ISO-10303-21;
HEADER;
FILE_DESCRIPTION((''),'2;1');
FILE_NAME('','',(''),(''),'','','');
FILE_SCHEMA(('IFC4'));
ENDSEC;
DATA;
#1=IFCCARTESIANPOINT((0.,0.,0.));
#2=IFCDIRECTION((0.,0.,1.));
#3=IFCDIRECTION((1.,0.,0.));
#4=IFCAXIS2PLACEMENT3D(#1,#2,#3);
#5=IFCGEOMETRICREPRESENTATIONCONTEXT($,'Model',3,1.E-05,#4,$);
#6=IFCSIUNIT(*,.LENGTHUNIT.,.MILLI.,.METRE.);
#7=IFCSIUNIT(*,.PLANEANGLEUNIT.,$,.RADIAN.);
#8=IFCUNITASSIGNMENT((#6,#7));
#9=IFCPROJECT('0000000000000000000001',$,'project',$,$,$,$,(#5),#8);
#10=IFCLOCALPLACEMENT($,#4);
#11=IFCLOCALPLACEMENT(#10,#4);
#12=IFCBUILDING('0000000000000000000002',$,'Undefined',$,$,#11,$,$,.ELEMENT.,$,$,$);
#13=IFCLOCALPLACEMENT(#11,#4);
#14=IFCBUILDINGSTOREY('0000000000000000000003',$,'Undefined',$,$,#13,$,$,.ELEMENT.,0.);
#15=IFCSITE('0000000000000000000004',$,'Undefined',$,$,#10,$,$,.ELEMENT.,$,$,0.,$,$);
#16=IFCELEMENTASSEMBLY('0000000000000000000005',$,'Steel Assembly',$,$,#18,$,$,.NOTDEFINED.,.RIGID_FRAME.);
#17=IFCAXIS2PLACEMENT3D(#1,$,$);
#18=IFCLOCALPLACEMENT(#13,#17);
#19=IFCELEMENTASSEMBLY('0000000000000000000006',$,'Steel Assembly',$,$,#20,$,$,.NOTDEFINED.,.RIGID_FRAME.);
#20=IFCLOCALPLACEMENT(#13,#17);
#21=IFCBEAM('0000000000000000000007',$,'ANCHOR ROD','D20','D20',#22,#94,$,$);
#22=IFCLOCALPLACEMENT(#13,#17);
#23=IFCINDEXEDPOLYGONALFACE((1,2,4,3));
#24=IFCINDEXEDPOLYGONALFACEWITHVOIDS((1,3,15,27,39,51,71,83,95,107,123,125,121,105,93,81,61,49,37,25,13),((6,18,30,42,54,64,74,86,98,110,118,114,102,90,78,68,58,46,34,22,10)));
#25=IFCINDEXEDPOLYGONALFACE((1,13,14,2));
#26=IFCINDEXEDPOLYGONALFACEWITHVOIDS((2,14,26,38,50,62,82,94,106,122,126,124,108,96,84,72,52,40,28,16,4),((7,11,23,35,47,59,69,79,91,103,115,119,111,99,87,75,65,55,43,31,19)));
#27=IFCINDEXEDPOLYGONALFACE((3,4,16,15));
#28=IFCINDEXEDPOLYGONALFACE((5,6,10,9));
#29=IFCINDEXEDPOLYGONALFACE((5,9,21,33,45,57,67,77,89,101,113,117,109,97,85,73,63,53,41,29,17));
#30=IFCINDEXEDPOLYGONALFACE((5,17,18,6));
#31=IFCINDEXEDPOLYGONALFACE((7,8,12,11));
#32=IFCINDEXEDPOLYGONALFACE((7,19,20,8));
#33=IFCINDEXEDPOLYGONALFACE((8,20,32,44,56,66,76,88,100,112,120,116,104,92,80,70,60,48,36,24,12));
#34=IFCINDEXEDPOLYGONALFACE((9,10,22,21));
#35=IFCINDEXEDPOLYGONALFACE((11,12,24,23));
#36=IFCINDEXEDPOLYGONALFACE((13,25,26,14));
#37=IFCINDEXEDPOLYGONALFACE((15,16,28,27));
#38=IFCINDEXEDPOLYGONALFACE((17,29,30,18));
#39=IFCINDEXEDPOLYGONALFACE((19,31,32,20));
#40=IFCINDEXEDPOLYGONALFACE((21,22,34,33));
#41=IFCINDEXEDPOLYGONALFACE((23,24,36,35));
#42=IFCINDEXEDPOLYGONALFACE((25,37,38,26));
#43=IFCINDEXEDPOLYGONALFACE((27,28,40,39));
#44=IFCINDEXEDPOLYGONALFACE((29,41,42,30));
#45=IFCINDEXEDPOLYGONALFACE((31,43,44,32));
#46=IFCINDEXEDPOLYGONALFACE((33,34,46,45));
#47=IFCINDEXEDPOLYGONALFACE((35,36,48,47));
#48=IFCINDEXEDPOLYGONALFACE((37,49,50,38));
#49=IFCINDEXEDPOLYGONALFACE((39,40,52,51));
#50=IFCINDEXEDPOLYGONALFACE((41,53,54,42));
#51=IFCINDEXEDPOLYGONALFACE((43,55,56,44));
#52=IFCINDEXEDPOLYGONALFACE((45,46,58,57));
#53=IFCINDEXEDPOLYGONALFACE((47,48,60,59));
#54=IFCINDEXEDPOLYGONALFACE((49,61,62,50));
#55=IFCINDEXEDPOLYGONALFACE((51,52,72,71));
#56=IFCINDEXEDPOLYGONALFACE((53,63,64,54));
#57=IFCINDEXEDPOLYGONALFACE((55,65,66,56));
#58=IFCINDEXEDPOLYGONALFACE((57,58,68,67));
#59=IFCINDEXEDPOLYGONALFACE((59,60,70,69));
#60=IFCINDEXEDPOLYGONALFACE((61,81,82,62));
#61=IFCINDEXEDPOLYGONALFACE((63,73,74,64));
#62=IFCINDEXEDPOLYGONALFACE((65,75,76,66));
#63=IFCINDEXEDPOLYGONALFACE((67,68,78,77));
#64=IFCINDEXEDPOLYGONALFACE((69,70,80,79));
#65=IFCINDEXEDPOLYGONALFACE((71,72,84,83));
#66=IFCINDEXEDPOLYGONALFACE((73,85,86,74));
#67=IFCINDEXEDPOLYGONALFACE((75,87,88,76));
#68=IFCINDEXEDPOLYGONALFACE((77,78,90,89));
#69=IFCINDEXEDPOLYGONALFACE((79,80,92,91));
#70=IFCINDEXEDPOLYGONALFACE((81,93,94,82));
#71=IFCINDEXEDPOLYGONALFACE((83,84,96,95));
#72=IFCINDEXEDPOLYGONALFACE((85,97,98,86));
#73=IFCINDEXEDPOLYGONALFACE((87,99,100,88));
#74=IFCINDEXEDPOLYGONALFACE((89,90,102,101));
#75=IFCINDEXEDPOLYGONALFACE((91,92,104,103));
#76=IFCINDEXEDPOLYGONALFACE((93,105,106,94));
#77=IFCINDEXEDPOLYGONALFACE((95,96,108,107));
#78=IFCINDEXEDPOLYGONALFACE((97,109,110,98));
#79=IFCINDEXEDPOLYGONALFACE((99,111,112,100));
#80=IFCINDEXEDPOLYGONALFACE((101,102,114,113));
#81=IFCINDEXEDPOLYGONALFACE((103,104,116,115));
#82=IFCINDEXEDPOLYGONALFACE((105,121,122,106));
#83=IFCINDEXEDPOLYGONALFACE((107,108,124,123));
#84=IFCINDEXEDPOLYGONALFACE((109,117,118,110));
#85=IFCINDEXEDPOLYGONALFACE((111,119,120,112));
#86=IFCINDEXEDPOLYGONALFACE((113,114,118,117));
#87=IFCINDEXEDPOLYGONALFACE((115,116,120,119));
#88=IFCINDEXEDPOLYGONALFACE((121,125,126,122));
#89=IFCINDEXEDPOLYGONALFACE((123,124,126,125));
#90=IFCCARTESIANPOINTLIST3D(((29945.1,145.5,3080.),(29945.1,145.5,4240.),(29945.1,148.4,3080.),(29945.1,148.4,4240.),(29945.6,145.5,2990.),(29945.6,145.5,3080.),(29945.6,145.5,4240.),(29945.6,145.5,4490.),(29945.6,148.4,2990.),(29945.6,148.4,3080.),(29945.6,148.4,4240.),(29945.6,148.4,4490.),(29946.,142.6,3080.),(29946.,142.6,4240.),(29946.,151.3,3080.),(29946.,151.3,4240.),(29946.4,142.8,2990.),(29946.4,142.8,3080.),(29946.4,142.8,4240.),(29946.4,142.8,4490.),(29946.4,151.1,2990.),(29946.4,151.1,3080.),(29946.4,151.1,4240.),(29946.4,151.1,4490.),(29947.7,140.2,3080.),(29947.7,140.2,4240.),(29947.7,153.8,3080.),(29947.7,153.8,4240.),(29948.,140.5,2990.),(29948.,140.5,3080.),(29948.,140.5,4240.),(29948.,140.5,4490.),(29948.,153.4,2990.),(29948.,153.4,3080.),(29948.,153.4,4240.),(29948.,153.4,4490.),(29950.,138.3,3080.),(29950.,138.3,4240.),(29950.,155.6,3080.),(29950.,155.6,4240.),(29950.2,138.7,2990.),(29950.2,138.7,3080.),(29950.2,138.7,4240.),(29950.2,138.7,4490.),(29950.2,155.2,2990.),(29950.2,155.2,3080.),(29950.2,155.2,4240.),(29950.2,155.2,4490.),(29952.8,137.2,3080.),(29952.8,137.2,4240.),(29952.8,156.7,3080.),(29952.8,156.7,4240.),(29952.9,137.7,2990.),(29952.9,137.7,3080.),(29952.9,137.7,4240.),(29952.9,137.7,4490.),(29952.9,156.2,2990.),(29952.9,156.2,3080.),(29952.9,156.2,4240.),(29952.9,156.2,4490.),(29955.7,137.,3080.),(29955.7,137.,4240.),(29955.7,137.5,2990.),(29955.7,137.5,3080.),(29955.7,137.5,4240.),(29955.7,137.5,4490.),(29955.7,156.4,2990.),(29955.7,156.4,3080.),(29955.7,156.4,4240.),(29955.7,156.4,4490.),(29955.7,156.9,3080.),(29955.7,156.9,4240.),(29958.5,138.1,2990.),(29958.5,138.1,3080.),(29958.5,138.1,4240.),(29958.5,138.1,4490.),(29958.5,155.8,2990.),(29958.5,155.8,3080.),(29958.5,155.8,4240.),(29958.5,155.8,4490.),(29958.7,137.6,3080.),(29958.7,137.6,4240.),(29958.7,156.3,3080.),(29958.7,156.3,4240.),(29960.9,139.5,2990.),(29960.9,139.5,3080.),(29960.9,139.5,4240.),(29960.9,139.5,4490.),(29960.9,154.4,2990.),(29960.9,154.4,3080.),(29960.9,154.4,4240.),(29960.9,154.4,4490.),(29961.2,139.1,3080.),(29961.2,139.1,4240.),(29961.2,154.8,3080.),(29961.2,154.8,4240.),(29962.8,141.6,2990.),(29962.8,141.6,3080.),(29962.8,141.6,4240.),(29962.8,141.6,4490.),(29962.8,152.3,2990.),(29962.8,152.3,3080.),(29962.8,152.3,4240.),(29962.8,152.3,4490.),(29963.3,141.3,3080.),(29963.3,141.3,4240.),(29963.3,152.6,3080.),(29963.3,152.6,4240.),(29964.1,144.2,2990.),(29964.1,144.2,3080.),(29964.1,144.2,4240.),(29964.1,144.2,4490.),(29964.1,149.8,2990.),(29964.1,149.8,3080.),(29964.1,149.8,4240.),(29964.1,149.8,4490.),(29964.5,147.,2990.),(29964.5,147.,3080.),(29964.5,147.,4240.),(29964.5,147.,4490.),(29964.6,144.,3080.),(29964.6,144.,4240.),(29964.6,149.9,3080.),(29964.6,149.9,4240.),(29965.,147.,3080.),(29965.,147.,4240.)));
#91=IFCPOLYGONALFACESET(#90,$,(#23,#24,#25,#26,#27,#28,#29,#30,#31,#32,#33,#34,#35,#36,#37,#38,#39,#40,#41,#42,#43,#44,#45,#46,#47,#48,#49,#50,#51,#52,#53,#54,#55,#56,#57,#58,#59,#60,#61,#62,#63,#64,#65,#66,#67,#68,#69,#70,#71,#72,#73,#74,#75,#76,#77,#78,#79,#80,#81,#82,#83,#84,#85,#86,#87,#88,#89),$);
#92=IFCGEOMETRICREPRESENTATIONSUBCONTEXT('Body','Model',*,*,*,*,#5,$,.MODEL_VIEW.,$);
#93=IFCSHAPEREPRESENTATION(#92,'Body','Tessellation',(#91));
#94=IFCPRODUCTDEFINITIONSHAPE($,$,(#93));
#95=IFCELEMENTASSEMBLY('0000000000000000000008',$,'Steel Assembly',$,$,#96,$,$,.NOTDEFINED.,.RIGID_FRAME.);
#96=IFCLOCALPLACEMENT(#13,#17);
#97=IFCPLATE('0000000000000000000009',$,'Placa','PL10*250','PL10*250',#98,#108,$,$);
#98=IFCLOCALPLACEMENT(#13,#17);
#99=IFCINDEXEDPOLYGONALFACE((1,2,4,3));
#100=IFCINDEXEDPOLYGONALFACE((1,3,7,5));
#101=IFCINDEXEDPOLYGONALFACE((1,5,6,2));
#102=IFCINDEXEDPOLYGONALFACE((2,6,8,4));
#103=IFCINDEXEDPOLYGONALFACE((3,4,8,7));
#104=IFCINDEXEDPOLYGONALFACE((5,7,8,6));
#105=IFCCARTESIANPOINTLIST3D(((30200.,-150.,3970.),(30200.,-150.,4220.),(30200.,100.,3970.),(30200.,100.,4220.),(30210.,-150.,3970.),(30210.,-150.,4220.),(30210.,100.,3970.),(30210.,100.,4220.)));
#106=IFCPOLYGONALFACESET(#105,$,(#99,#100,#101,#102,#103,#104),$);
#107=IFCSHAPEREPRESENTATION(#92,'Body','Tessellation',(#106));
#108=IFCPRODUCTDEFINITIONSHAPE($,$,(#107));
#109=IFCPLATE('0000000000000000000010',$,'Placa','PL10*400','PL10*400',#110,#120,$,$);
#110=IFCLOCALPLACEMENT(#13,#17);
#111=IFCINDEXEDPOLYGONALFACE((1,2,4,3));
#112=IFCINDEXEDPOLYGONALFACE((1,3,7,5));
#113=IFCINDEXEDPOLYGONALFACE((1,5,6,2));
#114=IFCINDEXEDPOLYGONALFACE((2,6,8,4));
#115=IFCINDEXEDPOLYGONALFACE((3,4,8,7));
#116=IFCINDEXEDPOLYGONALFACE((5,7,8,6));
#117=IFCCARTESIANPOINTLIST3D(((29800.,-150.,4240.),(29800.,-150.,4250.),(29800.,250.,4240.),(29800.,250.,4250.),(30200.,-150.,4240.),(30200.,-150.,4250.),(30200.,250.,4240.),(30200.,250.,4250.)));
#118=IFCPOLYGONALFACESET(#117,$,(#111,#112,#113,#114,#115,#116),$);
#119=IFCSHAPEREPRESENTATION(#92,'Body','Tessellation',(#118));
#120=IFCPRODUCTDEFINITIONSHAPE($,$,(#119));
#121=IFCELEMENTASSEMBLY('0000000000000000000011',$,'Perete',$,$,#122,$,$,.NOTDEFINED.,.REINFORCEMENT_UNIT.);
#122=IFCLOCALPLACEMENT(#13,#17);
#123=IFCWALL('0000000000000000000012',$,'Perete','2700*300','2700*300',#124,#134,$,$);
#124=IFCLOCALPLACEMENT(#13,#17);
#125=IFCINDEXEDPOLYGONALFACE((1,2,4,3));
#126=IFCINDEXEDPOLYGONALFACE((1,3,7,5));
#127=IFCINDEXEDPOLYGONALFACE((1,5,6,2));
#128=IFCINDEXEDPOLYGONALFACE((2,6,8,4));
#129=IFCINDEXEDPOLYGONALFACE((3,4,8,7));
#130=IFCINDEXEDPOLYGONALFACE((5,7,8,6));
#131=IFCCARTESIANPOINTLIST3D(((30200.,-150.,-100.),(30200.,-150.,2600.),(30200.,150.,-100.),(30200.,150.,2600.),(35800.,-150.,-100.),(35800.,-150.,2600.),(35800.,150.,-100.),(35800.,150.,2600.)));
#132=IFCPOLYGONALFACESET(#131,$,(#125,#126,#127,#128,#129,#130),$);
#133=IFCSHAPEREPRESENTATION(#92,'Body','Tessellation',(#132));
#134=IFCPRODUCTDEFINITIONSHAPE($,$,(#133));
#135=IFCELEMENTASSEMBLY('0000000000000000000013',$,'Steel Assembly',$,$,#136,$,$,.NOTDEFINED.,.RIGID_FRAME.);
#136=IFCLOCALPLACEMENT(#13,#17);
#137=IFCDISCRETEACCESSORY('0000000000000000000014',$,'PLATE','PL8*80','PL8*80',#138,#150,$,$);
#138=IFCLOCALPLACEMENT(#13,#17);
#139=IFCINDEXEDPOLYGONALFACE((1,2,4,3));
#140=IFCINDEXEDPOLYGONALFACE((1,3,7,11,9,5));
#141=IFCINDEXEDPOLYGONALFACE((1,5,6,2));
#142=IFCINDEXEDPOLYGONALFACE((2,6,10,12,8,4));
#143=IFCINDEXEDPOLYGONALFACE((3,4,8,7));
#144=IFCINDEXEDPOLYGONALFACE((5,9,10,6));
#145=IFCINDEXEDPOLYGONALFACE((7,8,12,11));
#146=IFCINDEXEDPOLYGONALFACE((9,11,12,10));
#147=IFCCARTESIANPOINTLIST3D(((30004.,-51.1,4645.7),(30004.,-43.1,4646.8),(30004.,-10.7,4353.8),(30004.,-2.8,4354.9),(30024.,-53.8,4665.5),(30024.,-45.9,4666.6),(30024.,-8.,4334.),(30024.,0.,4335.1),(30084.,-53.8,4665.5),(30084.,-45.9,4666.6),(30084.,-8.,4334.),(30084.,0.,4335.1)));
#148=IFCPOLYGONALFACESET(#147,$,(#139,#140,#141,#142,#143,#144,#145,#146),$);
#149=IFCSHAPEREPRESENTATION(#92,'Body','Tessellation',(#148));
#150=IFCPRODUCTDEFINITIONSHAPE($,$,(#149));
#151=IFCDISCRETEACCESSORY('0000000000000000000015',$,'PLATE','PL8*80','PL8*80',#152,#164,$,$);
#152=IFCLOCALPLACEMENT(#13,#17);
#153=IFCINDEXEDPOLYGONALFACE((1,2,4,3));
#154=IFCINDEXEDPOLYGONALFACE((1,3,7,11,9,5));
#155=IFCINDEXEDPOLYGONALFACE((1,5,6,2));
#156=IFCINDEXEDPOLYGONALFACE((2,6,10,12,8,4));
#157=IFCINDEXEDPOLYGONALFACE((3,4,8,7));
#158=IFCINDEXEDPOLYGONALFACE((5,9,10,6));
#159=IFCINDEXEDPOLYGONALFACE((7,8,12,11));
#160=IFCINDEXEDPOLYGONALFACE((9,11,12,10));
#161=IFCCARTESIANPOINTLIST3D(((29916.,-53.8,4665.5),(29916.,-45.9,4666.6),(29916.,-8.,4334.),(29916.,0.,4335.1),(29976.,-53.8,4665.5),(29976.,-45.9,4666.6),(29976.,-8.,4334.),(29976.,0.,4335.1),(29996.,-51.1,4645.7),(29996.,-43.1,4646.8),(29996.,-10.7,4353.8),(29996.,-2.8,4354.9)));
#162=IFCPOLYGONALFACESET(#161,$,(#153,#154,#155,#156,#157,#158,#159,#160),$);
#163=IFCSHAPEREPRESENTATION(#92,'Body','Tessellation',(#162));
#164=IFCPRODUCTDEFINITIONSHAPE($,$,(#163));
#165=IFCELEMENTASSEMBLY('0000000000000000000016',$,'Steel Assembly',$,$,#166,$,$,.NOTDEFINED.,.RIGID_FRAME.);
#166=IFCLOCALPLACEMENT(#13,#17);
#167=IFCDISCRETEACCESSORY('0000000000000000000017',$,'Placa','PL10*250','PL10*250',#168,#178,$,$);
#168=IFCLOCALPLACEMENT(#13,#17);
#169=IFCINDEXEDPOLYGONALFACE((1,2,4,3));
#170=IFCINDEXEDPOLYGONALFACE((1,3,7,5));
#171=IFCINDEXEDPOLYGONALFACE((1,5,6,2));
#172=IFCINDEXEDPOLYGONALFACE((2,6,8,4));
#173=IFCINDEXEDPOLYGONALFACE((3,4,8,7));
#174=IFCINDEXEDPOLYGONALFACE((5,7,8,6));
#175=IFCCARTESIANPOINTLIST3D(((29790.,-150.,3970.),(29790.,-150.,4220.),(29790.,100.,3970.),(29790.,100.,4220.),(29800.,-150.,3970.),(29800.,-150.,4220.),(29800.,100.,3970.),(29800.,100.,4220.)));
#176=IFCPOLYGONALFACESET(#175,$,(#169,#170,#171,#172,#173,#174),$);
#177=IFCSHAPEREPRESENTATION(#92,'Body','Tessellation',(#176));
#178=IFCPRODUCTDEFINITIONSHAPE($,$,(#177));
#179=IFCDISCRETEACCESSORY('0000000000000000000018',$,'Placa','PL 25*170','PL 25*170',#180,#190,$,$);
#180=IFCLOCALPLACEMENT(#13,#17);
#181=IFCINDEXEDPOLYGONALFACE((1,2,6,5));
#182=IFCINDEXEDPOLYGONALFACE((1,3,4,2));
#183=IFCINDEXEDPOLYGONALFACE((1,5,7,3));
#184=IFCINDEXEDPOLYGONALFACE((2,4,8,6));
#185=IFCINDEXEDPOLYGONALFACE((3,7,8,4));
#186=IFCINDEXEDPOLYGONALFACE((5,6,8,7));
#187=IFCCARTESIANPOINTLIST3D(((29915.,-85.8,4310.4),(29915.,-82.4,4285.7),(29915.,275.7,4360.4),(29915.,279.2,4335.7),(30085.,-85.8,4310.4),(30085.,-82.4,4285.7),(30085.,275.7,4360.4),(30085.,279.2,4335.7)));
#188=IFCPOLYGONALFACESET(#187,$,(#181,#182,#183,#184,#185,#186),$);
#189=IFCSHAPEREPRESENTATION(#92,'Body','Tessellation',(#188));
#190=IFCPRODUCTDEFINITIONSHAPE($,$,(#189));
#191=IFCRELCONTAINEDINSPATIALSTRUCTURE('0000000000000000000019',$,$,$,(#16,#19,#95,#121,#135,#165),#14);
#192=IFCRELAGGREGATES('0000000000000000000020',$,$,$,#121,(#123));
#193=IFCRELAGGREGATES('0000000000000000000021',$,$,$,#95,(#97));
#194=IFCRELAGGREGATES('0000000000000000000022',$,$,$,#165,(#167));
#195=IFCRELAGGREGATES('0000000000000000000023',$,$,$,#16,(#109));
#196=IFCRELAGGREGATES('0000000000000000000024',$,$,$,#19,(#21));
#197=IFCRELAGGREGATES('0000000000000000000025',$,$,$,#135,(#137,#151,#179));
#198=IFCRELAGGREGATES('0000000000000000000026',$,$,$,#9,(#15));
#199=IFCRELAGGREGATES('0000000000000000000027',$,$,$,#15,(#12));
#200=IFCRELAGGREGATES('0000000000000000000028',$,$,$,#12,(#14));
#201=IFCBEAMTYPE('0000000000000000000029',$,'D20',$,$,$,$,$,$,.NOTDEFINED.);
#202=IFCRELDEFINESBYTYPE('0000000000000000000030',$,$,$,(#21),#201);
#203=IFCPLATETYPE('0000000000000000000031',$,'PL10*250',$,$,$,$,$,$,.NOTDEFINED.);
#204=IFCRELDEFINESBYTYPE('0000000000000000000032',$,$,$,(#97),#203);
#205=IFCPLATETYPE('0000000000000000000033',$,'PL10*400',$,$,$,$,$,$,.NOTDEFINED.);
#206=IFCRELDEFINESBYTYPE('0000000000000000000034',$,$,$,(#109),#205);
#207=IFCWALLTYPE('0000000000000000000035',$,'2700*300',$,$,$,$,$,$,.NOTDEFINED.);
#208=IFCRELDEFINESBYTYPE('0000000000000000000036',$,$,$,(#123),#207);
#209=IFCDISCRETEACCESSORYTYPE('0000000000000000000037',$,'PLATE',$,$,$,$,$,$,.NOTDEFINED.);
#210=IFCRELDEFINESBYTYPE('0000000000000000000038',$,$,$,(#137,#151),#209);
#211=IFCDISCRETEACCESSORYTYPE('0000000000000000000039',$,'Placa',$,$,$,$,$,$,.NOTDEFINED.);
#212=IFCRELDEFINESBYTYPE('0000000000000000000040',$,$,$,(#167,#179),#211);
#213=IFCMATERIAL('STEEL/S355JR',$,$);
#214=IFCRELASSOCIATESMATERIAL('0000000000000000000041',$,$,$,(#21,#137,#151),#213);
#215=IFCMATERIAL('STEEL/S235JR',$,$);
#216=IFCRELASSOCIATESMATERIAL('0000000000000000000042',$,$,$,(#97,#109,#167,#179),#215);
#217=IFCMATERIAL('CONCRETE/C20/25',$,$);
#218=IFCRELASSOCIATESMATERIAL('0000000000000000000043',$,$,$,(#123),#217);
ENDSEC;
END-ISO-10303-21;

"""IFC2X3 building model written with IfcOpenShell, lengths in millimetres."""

from ifc_helpers import new_model, si_unit, frame, frame_2d, origin_with_axes, origin_2d_with_axis, place, context, subcontext, project, spatial, polyline, rectangle, circle, outline, extrude, boolean, material, type_object, element, aggregate, save


model = new_model("IFC2X3")

# Units and contexts
model_context = context("Model", 3, precision=1e-05, world=origin_with_axes())
body_context = subcontext(model_context, "Body", "Model", "MODEL_VIEW")
ifc_project = project(units=[si_unit("LENGTHUNIT", "METRE", prefix="MILLI"), si_unit("PLANEANGLEUNIT", "RADIAN")], contexts=[model_context])

# Site, building, storey
site_placement = place(None, origin_with_axes())
site = spatial("IfcSite", under=ifc_project, at=site_placement, Name="Undefined", CompositionType="ELEMENT", RefElevation=0.0)
building_placement = place(site_placement, origin_with_axes())
building = spatial("IfcBuilding", under=site, at=building_placement, Name="Undefined", CompositionType="ELEMENT")
storey_placement = place(building_placement, origin_with_axes())
storey = spatial("IfcBuildingStorey", under=building, at=storey_placement, Name="Undefined", CompositionType="ELEMENT", Elevation=0.0)

# Shared definitions
ifc_material_1 = material(Name="CONCRETE/C20/25")

# Element assembly
assembly_1_placement = place(storey_placement, origin_with_axes())
assembly_1 = element("IfcElementAssembly", 1, at=assembly_1_placement, inside=storey, Name="Steel Assembly", AssemblyPlace="NOTDEFINED", PredefinedType="RIGID_FRAME")
ifc_material_2 = material(Name="STEEL/S355JR")
beam_type = type_object("IfcBeamType", Name="D20", PredefinedType="NOTDEFINED")

# Element assembly, beam
assembly_2_placement = place(storey_placement, origin_with_axes())
assembly_2 = element("IfcElementAssembly", 2, at=assembly_2_placement, inside=storey, Name="Steel Assembly", AssemblyPlace="NOTDEFINED", PredefinedType="RIGID_FRAME")
beam_1_placement = place(assembly_2_placement, frame((29955.0, 147.0, 4240.0), z_axis=(0.0, 1.0, 0.0), x_axis=(0.0, 0.0, -1.0)))
beam_1 = element("IfcBeam", 3, at=beam_1_placement, type_object=beam_type, material=ifc_material_2, Name="ANCHOR ROD", Description="D20", ObjectType="D20", context=body_context, shape_type="CSG", body=[
    boolean("UNION", boolean("UNION", extrude(circle(Radius=10.0, at=origin_2d_with_axis()), frame((1160.0, 0.0, 0.0), z_axis=(-1.0, 0.0, 0.0), x_axis=(0.0, -1.0, 0.0)), (0.0, 0.0, 1.0), 1160.0), extrude(circle(Radius=9.5, at=origin_2d_with_axis()), frame((1250.0, 0.0, 0.0), z_axis=(-1.0, 0.0, 0.0), x_axis=(0.0, -1.0, 0.0)), (0.0, 0.0, 1.0), 90.0)), extrude(circle(Radius=9.5, at=origin_2d_with_axis()), frame((0.0, 0.0, 0.0), z_axis=(-1.0, 0.0, 0.0), x_axis=(0.0, -1.0, 0.0)), (0.0, 0.0, 1.0), 250.0)),
])

# Element assembly, plate
assembly_3_placement = place(storey_placement, origin_with_axes())
assembly_3 = element("IfcElementAssembly", 4, at=assembly_3_placement, inside=storey, Name="Steel Assembly", AssemblyPlace="NOTDEFINED", PredefinedType="RIGID_FRAME")
ifc_material_3 = material(Name="STEEL/S235JR")
plate_type_1 = type_object("IfcPlateType", Name="PL10*250", PredefinedType="NOTDEFINED")
plate_1_placement = place(assembly_3_placement, frame((30205.0, -150.0, 4220.0), z_axis=(1.0, 0.0, 0.0), x_axis=(0.0, 0.0, -1.0)))
plate_1 = element("IfcPlate", 5, at=plate_1_placement, type_object=plate_type_1, material=ifc_material_3, Name="Placa", Description="PL10*250", ObjectType="PL10*250", context=body_context, shape_type="SweptSolid", body=[
    extrude(outline(polyline([(0.0, 0.0), (250.0, 0.0), (250.0, 250.0), (0.0, 250.0), (0.0, 0.0)])), frame((0.0, 0.0, -5.0), z_axis=(0.0, 0.0, 1.0), x_axis=(1.0, 0.0, 0.0)), (0.0, 0.0, 1.0), 10.0),
])

# Plate
plate_type_2 = type_object("IfcPlateType", Name="PL10*400", PredefinedType="NOTDEFINED")
plate_2_placement = place(assembly_1_placement, frame((29800.0, 250.0, 4245.0), z_axis=(0.0, 0.0, 1.0), x_axis=(0.0, -1.0, 0.0)))
plate_2 = element("IfcPlate", 6, at=plate_2_placement, type_object=plate_type_2, material=ifc_material_3, Name="Placa", Description="PL10*400", ObjectType="PL10*400", context=body_context, shape_type="SweptSolid", body=[
    extrude(outline(polyline([(0.0, 0.0), (400.0, 0.0), (400.0, 400.0), (0.0, 400.0), (0.0, 0.0)])), frame((0.0, 0.0, -5.0), z_axis=(0.0, 0.0, 1.0), x_axis=(1.0, 0.0, 0.0)), (0.0, 0.0, 1.0), 10.0),
])

# Element assembly, wall
assembly_4_placement = place(storey_placement, origin_with_axes())
assembly_4 = element("IfcElementAssembly", 7, at=assembly_4_placement, inside=storey, Name="Perete", AssemblyPlace="NOTDEFINED", PredefinedType="REINFORCEMENT_UNIT")
wall_type = type_object("IfcWallType", Name="2700*300", PredefinedType="NOTDEFINED")
wall_placement = place(assembly_4_placement, frame((30200.0, 0.0, -100.0), z_axis=(0.0, 0.0, 1.0), x_axis=(1.0, 0.0, 0.0)))
wall = element("IfcWall", 8, at=wall_placement, type_object=wall_type, material=ifc_material_1, Name="Perete", Description="2700*300", ObjectType="2700*300", context=body_context, shape_type="SweptSolid", body=[
    extrude(rectangle(XDim=5600.0, YDim=300.0, at=frame_2d((0.0, 2800.0), x_axis=(0.0, -1.0))), frame((0.0, 0.0, 0.0), z_axis=(0.0, 0.0, 1.0), x_axis=(0.0, -1.0, 0.0)), (0.0, 0.0, 1.0), 2700.0),
])
aggregate(assembly_4, [wall])

# Element assembly, discrete accessories
assembly_5_placement = place(storey_placement, origin_with_axes())
assembly_5 = element("IfcElementAssembly", 9, at=assembly_5_placement, inside=storey, Name="Steel Assembly", AssemblyPlace="NOTDEFINED", PredefinedType="RIGID_FRAME")
discrete_accessory_type_1 = type_object("IfcDiscreteAccessoryType", Name="PLATE")
discrete_accessory_1_placement = place(assembly_5_placement, frame((30084.0, -4.0, 4334.6), z_axis=(0.0, 0.990574, 0.13698), x_axis=(-1.0, 0.0, 0.0)))
discrete_accessory_1 = element("IfcDiscreteAccessory", 10, at=discrete_accessory_1_placement, type_object=discrete_accessory_type_1, material=ifc_material_2, Name="PLATE", Description="PL8*80", ObjectType="PL8*80", context=body_context, shape_type="SweptSolid", body=[
    extrude(outline(polyline([(0.0, 0.0), (60.0, 0.0), (80.0, 20.0), (80.0, 314.6), (60.0, 334.6), (0.0, 334.6), (0.0, 0.0)])), frame((0.0, 0.0, -4.0), z_axis=(0.0, 0.0, 1.0), x_axis=(1.0, 0.0, 0.0)), (0.0, 0.0, 1.0), 8.0),
])
discrete_accessory_2_placement = place(assembly_5_placement, frame((29996.0, -4.0, 4334.6), z_axis=(0.0, 0.990574, 0.13698), x_axis=(-1.0, 0.0, 0.0)))
discrete_accessory_2 = element("IfcDiscreteAccessory", 11, at=discrete_accessory_2_placement, type_object=discrete_accessory_type_1, material=ifc_material_2, Name="PLATE", Description="PL8*80", ObjectType="PL8*80", context=body_context, shape_type="SweptSolid", body=[
    extrude(outline(polyline([(0.0, 20.0), (20.0, 0.0), (80.0, 0.0), (80.0, 334.6), (20.0, 334.6), (0.0, 314.6), (0.0, 20.0)])), frame((0.0, 0.0, -4.0), z_axis=(0.0, 0.0, 1.0), x_axis=(1.0, 0.0, 0.0)), (0.0, 0.0, 1.0), 8.0),
])

aggregate(assembly_3, [plate_1])

# Element assembly, discrete accessory
assembly_6_placement = place(storey_placement, origin_with_axes())
assembly_6 = element("IfcElementAssembly", 12, at=assembly_6_placement, inside=storey, Name="Steel Assembly", AssemblyPlace="NOTDEFINED", PredefinedType="RIGID_FRAME")
discrete_accessory_type_2 = type_object("IfcDiscreteAccessoryType", Name="Placa")
discrete_accessory_3_placement = place(assembly_6_placement, frame((29795.0, -150.0, 4220.0), z_axis=(1.0, 0.0, 0.0), x_axis=(0.0, 0.0, -1.0)))
discrete_accessory_3 = element("IfcDiscreteAccessory", 13, at=discrete_accessory_3_placement, type_object=discrete_accessory_type_2, material=ifc_material_3, Name="Placa", Description="PL10*250", ObjectType="PL10*250", context=body_context, shape_type="SweptSolid", body=[
    extrude(outline(polyline([(0.0, 0.0), (250.0, 0.0), (250.0, 250.0), (0.0, 250.0), (0.0, 0.0)])), frame((0.0, 0.0, -5.0), z_axis=(0.0, 0.0, 1.0), x_axis=(1.0, 0.0, 0.0)), (0.0, 0.0, 1.0), 10.0),
])

# Discrete accessory
discrete_accessory_4_placement = place(assembly_5_placement, frame((30085.0, -84.1, 4298.1), z_axis=(0.0, -0.13698, 0.990574), x_axis=(0.0, 0.990574, 0.13698)))
discrete_accessory_4 = element("IfcDiscreteAccessory", 14, at=discrete_accessory_4_placement, type_object=discrete_accessory_type_2, material=ifc_material_3, Name="Placa", Description="PL 25*170", ObjectType="PL 25*170", context=body_context, shape_type="SweptSolid", body=[
    extrude(outline(polyline([(0.0, 0.0), (365.0, 0.0), (365.0, 170.0), (0.0, 170.0), (0.0, 0.0)])), frame((0.0, 0.0, -12.5), z_axis=(0.0, 0.0, 1.0), x_axis=(1.0, 0.0, 0.0)), (0.0, 0.0, 1.0), 25.0),
])

aggregate(assembly_6, [discrete_accessory_3])
aggregate(assembly_1, [plate_2])

aggregate(assembly_2, [beam_1])

aggregate(assembly_5, [discrete_accessory_1, discrete_accessory_2, discrete_accessory_4])

save(model, "model.ifc")
